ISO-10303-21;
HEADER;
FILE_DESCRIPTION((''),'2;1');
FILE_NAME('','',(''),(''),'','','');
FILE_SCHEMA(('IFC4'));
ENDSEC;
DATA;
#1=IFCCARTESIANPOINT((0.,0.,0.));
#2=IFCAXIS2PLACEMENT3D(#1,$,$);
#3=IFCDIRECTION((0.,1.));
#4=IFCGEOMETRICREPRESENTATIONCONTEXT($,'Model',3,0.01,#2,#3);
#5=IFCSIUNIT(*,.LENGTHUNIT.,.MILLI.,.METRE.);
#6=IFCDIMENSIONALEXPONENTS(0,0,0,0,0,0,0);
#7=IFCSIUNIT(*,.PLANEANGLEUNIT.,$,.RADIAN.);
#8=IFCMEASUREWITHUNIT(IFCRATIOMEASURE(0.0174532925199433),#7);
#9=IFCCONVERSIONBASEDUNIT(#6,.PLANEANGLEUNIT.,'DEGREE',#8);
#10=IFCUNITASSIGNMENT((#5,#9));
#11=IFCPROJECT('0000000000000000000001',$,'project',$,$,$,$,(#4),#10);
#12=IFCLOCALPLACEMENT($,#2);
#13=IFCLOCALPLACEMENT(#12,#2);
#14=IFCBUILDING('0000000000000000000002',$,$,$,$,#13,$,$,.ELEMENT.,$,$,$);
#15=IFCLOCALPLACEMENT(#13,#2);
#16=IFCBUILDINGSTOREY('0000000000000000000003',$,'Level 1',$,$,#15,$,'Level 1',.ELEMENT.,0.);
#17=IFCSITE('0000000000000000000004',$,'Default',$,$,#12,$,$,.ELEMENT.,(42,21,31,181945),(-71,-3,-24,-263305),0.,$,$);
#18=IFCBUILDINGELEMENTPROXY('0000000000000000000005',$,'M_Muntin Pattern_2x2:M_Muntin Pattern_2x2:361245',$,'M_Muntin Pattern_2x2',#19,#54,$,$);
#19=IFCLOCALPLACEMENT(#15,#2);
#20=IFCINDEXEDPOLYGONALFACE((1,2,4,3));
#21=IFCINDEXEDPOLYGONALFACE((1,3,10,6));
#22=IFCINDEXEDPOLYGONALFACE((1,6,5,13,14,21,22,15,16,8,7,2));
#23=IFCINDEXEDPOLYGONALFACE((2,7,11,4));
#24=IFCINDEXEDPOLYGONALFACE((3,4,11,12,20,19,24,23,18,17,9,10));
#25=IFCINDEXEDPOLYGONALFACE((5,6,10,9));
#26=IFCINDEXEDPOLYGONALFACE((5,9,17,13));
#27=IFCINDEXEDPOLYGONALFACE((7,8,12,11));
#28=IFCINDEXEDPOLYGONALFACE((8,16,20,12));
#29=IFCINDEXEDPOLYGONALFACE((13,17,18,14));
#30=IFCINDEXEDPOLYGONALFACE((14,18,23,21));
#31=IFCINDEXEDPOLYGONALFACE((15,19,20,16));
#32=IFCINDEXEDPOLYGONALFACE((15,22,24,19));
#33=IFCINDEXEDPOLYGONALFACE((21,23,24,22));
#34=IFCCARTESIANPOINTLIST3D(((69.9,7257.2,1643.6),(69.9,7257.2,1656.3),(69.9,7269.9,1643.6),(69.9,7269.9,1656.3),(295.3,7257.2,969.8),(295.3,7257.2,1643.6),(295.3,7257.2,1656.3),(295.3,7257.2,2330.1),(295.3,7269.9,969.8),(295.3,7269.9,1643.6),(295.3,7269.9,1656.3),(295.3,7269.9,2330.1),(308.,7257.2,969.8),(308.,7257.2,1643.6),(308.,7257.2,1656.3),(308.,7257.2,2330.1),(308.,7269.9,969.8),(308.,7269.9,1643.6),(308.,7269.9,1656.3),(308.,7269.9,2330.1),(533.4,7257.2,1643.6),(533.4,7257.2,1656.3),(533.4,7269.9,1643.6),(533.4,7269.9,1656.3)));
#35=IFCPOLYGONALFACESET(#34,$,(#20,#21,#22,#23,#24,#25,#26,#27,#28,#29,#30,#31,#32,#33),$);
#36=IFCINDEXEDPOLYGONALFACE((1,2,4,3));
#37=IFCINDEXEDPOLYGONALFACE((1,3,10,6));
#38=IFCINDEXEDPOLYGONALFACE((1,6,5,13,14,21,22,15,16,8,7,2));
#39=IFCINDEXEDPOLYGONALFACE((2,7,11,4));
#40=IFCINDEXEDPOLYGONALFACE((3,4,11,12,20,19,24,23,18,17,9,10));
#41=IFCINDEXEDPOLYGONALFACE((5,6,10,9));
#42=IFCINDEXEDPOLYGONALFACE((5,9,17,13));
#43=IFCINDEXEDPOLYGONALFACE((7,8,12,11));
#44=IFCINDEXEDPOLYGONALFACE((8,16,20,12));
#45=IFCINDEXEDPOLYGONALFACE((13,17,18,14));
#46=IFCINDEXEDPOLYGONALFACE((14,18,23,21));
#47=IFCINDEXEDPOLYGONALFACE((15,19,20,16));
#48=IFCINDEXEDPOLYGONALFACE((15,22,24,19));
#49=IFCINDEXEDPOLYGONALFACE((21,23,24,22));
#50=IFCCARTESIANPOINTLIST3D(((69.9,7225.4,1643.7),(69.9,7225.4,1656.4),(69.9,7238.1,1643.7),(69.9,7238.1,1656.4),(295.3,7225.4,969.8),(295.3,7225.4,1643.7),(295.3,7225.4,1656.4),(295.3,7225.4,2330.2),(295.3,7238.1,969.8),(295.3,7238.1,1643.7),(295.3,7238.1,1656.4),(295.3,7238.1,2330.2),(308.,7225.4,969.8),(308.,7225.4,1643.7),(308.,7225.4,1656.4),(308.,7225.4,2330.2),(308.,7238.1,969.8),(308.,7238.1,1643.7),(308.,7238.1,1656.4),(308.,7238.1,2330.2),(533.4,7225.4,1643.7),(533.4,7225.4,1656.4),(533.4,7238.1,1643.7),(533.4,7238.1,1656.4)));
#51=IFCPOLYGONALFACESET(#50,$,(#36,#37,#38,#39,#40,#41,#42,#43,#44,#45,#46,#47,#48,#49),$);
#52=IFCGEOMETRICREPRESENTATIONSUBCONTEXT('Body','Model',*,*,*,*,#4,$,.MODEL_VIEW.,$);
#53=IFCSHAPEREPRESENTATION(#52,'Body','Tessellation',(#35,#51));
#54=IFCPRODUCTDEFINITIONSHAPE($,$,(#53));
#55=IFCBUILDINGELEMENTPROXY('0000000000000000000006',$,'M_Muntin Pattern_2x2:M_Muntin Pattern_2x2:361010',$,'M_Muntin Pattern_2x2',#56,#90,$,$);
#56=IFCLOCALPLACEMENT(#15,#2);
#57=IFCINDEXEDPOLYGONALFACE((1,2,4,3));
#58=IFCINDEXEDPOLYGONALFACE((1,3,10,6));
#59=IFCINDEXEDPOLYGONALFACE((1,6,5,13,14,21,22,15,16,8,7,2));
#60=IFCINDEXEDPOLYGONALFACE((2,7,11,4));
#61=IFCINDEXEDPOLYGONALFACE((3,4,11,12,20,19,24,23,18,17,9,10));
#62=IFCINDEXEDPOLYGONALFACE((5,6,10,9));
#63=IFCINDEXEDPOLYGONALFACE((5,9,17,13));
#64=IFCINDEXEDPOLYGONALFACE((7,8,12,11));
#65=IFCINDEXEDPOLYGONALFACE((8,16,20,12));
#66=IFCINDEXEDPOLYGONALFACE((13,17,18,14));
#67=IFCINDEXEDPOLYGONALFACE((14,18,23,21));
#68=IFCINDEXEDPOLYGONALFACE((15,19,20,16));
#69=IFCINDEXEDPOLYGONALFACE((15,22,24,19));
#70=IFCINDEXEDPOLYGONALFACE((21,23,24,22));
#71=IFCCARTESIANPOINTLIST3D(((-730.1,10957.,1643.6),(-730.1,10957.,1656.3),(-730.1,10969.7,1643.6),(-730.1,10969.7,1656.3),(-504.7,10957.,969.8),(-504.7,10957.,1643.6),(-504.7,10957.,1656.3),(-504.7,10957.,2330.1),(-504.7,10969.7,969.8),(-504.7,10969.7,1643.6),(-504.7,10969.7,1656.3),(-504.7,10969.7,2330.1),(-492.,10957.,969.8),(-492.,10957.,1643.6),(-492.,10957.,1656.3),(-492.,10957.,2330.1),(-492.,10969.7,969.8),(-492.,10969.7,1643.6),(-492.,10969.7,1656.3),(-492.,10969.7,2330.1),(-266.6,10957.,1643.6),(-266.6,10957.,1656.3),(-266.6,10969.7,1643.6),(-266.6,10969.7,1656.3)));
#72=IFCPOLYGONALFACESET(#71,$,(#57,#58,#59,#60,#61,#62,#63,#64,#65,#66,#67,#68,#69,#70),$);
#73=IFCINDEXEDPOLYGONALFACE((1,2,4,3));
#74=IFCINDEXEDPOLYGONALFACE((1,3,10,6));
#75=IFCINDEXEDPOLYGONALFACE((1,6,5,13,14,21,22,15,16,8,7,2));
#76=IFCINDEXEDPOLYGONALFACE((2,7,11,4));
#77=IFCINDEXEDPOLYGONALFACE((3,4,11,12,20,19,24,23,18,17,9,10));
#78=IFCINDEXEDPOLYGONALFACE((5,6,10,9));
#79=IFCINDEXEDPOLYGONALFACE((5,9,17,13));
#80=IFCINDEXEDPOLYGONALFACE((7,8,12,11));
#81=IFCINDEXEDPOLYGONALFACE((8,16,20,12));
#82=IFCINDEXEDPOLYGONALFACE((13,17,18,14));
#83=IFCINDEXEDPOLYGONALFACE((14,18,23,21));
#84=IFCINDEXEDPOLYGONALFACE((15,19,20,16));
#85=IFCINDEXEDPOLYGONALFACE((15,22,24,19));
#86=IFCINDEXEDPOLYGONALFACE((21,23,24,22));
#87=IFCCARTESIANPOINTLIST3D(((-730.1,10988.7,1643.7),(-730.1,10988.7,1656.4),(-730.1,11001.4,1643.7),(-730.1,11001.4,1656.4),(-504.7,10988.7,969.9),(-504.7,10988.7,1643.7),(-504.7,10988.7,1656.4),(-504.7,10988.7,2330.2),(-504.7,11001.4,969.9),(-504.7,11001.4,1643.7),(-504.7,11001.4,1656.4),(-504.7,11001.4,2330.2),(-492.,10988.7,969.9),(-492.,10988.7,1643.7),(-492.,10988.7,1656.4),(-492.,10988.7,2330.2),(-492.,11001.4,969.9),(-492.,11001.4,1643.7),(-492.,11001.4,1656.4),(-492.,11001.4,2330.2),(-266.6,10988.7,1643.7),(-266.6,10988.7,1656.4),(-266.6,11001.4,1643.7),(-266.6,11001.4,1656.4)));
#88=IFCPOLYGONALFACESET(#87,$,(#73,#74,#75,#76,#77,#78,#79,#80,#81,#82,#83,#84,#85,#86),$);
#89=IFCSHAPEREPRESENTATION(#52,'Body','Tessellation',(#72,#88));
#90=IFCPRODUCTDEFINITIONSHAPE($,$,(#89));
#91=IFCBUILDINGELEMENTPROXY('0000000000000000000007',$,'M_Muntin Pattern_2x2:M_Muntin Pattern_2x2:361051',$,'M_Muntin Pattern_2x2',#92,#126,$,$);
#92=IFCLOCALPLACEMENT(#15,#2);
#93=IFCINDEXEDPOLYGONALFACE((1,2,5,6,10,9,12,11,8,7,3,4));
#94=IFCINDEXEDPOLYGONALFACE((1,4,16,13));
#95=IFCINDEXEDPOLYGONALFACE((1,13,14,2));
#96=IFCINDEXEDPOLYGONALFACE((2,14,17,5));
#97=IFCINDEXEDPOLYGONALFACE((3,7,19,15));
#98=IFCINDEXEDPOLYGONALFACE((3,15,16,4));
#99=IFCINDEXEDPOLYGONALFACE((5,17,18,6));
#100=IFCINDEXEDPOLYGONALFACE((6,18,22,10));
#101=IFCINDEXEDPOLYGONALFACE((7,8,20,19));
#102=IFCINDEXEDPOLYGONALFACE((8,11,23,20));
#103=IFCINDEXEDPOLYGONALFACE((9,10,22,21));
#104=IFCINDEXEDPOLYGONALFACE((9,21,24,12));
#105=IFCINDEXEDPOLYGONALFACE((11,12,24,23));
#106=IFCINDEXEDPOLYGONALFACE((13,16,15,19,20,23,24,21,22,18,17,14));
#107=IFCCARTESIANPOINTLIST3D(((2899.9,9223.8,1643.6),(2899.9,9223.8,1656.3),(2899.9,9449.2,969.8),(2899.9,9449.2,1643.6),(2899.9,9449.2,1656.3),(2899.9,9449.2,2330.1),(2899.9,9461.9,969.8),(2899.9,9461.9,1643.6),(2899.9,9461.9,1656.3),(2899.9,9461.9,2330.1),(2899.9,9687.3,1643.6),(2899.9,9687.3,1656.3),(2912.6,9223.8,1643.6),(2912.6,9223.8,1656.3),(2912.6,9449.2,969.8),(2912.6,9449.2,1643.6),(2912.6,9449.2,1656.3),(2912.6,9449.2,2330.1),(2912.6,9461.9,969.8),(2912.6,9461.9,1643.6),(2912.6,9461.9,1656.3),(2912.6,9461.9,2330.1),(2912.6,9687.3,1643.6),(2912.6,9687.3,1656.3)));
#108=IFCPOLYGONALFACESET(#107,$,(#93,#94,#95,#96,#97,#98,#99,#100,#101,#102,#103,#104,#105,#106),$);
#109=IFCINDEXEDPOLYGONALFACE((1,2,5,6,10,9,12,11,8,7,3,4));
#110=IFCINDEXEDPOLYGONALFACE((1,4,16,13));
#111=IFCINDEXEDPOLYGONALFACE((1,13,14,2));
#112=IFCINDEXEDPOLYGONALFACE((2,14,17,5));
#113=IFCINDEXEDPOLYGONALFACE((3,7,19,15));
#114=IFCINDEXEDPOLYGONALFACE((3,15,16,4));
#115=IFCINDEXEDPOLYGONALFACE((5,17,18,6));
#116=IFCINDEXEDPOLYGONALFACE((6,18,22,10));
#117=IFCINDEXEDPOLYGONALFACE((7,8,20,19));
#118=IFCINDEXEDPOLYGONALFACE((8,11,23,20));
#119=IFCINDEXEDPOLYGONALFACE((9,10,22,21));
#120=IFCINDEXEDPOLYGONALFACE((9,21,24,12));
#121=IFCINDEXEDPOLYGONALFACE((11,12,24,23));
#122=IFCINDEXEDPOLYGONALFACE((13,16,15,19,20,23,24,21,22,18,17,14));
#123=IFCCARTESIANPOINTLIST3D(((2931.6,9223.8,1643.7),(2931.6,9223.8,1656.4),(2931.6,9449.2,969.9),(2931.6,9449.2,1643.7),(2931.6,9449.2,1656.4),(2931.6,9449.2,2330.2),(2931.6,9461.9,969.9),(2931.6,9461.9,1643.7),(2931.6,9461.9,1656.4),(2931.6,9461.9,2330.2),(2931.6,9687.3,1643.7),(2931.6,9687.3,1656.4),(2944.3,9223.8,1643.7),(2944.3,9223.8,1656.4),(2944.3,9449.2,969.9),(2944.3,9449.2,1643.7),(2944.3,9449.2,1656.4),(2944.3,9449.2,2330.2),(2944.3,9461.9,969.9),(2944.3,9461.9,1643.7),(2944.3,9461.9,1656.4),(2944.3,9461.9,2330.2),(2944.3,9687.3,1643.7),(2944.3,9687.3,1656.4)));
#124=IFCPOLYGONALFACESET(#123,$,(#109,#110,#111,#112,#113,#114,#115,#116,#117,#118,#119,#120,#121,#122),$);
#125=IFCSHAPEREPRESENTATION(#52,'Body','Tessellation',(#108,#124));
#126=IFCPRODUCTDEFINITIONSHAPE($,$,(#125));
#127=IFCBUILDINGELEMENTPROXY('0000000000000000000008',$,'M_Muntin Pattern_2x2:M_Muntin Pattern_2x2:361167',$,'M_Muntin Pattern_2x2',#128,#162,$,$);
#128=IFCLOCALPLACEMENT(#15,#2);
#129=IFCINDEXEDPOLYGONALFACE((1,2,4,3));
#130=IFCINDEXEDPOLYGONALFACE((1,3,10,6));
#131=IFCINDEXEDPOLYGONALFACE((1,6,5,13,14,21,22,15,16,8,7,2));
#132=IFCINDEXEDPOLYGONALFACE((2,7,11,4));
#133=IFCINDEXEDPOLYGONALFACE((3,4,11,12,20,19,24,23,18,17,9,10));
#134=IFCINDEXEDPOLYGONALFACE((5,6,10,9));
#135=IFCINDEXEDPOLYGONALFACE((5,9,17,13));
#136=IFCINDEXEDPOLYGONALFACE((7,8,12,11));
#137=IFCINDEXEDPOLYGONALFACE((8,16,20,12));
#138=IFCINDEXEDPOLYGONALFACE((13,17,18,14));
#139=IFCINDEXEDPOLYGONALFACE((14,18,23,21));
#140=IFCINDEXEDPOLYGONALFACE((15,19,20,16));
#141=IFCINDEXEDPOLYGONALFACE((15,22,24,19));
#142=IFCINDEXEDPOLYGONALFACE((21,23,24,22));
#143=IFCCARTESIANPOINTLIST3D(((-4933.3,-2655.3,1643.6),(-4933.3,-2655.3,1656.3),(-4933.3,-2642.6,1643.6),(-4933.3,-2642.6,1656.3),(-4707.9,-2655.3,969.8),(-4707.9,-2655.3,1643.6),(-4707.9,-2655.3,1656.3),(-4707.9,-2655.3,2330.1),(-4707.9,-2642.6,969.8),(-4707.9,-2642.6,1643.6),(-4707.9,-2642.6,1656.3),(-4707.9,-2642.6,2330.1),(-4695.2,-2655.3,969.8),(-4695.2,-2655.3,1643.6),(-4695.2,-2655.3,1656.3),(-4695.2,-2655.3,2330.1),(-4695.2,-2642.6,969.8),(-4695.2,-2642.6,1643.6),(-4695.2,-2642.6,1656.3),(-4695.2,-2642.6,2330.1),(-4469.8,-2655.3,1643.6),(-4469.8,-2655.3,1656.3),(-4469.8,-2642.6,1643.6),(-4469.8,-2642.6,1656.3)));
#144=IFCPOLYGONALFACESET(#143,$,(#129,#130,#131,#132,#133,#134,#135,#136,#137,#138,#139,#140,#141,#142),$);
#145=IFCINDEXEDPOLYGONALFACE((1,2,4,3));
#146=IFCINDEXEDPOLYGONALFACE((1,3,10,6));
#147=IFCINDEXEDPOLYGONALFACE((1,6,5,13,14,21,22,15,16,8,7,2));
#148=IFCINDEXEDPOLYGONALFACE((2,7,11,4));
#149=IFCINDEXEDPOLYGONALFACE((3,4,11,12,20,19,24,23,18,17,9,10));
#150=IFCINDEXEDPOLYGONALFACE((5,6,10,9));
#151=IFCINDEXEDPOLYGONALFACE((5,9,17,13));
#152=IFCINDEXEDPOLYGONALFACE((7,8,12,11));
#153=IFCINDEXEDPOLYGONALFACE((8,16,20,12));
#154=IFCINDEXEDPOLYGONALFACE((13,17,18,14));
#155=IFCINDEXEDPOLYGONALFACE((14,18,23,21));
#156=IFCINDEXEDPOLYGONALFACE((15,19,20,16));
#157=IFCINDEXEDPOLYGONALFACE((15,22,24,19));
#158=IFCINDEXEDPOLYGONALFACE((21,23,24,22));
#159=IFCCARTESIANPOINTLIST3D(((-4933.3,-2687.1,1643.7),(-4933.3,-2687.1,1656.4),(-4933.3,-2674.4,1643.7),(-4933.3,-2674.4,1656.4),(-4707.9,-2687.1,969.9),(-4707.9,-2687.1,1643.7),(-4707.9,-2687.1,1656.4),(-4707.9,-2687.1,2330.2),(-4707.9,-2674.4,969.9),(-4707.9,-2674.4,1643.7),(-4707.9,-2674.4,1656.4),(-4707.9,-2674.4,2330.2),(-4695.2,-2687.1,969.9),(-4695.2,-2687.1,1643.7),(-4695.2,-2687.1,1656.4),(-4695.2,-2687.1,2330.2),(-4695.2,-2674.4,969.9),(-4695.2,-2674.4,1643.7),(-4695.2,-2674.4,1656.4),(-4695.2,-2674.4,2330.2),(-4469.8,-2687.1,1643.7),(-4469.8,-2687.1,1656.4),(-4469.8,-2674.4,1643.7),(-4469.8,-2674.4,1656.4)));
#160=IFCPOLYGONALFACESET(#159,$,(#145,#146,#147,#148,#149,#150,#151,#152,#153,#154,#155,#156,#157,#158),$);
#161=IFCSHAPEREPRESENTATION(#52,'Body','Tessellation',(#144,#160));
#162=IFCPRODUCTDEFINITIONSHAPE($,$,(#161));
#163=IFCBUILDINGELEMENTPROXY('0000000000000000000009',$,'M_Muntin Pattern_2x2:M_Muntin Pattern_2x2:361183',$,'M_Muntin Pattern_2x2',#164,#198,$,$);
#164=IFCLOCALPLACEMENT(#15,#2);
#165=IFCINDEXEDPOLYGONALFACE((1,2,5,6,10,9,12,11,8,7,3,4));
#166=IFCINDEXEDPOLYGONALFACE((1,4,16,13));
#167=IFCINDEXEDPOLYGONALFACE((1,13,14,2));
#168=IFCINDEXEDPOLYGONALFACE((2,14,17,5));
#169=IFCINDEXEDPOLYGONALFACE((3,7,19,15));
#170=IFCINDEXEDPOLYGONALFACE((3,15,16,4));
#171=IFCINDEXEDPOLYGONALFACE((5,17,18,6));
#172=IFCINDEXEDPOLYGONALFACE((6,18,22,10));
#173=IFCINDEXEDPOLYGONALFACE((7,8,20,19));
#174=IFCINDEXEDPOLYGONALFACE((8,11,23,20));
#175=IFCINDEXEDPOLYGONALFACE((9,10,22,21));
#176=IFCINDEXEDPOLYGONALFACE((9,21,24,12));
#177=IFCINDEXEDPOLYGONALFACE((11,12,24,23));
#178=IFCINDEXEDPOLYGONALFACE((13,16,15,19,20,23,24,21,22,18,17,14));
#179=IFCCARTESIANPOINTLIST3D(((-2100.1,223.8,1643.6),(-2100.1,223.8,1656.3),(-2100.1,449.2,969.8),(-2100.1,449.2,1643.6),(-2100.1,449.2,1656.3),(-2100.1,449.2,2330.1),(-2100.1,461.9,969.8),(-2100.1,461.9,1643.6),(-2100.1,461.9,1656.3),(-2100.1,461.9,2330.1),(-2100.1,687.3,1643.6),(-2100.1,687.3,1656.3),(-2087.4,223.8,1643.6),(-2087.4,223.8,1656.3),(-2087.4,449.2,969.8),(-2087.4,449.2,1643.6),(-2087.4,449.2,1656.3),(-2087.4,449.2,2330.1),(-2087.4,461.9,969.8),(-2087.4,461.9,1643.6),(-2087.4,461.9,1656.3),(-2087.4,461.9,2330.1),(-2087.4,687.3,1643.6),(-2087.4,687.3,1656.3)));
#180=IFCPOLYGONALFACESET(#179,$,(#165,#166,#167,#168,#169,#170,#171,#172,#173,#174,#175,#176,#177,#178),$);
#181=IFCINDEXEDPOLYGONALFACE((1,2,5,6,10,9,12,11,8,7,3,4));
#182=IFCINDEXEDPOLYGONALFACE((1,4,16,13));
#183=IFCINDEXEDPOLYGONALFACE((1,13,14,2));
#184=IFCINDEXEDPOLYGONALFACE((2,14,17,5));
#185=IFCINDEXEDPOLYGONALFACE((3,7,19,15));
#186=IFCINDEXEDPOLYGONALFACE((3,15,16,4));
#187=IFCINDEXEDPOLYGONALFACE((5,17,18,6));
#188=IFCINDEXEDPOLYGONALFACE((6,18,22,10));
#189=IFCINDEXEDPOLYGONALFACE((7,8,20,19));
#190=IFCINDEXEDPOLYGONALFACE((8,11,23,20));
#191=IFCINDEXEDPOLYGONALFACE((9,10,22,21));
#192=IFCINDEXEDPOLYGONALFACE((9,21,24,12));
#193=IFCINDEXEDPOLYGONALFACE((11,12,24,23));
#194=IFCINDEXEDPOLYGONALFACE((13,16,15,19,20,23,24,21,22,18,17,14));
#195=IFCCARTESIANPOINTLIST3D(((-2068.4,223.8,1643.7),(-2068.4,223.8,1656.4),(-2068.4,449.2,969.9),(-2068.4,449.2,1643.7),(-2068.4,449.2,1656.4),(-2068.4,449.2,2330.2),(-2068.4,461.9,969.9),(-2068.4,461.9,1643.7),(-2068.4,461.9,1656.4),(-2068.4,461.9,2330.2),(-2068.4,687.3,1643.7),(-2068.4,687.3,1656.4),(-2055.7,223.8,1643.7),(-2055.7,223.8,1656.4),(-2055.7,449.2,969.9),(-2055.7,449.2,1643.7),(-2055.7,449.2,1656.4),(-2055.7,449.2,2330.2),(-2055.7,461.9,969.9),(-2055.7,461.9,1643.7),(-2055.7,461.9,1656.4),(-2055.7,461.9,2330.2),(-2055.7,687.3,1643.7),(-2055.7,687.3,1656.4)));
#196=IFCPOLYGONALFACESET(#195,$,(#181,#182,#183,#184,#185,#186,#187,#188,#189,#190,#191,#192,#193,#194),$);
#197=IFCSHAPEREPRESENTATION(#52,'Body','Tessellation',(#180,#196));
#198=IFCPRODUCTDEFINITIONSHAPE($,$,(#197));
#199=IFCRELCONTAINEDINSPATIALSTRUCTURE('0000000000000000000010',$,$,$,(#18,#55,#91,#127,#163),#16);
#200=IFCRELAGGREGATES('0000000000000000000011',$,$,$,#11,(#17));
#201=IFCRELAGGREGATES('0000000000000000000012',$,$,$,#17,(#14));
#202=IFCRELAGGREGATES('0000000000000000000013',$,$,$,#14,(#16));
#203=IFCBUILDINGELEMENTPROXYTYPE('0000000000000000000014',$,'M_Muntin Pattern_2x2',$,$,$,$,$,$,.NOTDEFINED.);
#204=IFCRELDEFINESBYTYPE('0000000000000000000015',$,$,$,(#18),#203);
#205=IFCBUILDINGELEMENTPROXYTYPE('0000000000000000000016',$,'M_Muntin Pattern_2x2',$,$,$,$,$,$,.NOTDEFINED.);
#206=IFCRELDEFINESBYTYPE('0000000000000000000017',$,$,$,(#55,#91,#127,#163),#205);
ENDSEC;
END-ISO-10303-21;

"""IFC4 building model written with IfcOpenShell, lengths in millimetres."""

from ifc_helpers import new_model, entity, si_unit, converted_unit, direction, frame, origin, place, context, subcontext, project, spatial, polyline, outline, extrude, source, transform, mapped, type_object, type_shapes, element, save


model = new_model("IFC4")

# Units and contexts
model_context = context("Model", 3, precision=0.01, world=origin(), true_north=direction((0.0, 1.0)))
body_context = subcontext(model_context, "Body", "Model", "MODEL_VIEW")
ifc_project = project(units=[si_unit("LENGTHUNIT", "METRE", prefix="MILLI"), converted_unit("PLANEANGLEUNIT", "DEGREE", entity("IfcRatioMeasure", 0.0174532925199433), si_unit("PLANEANGLEUNIT", "RADIAN"), dimensions=[0, 0, 0, 0, 0, 0, 0])], contexts=[model_context])

# Site, building, storey
site_placement = place(None, origin())
site = spatial("IfcSite", under=ifc_project, at=site_placement, Name="Default", CompositionType="ELEMENT", RefLatitude=(42, 21, 31, 181945), RefLongitude=(-71, -3, -24, -263305), RefElevation=0.0)
building_placement = place(site_placement, origin())
building = spatial("IfcBuilding", under=site, at=building_placement, CompositionType="ELEMENT")
storey_placement = place(building_placement, origin())
storey = spatial("IfcBuildingStorey", under=building, at=storey_placement, Name="Level 1", LongName="Level 1", CompositionType="ELEMENT", Elevation=0.0)

# Building element proxies
building_element_proxy_type_1 = type_object("IfcBuildingElementProxyType", Name="M_Muntin Pattern_2x2", PredefinedType="NOTDEFINED")
shared_shape_1 = source(origin(), body_context, "Body", "SweptSolid", [
    extrude(outline(polyline([(6.4, -6.4), (680.1, -6.4), (680.1, 6.3), (6.4, 6.3), (6.4, 231.7), (-6.3, 231.7), (-6.3, 6.3), (-680.2, 6.3), (-680.2, -6.4), (-6.3, -6.4), (-6.3, -231.7), (6.4, -231.7), (6.4, -6.4)])), frame((0.0, 9.5, 680.1), z_axis=(0.0, 1.0, 0.0), x_axis=(0.0, 0.0, 1.0)), (0.0, 0.0, 1.0), 12.7),
    extrude(outline(polyline([(6.4, -6.4), (680.2, -6.4), (680.2, 6.3), (6.4, 6.3), (6.4, 231.7), (-6.3, 231.7), (-6.3, 6.3), (-680.2, 6.3), (-680.2, -6.4), (-6.3, -6.4), (-6.3, -231.7), (6.4, -231.7), (6.4, -6.4)])), frame((0.0, -22.2, 680.2), z_axis=(0.0, 1.0, 0.0), x_axis=(0.0, 0.0, 1.0)), (0.0, 0.0, 1.0), 12.7),
])
type_shapes(building_element_proxy_type_1, [shared_shape_1])
for number, where, name in (
    (1, (301.6, 7247.6, 969.8), "M_Muntin Pattern_2x2:M_Muntin Pattern_2x2:361245"),
):
    element("IfcBuildingElementProxy", number, at=place(storey_placement, frame(where)), inside=storey, type_object=building_element_proxy_type_1, Name=name, ObjectType="M_Muntin Pattern_2x2", context=body_context, shape_type="MappedRepresentation", body=[
        mapped(shared_shape_1, transform((0.0, 0.0, 0.0), scale=1.0)),
    ])
building_element_proxy_type_2 = type_object("IfcBuildingElementProxyType", Name="M_Muntin Pattern_2x2", PredefinedType="NOTDEFINED")
shared_shape_2 = source(origin(), body_context, "Body", "SweptSolid", [
    extrude(outline(polyline([(6.4, -6.4), (680.1, -6.4), (680.1, 6.3), (6.4, 6.3), (6.4, 231.7), (-6.3, 231.7), (-6.3, 6.3), (-680.2, 6.3), (-680.2, -6.4), (-6.3, -6.4), (-6.3, -231.7), (6.4, -231.7), (6.4, -6.4)])), frame((0.0, -22.2, 680.1), z_axis=(0.0, 1.0, 0.0), x_axis=(0.0, 0.0, 1.0)), (0.0, 0.0, 1.0), 12.7),
    extrude(outline(polyline([(6.4, -6.4), (680.1, -6.4), (680.1, 6.3), (6.4, 6.3), (6.4, 231.7), (-6.3, 231.7), (-6.3, 6.3), (-680.2, 6.3), (-680.2, -6.4), (-6.3, -6.4), (-6.3, -231.7), (6.4, -231.7), (6.4, -6.4)])), frame((0.0, 9.5, 680.2), z_axis=(0.0, 1.0, 0.0), x_axis=(0.0, 0.0, 1.0)), (0.0, 0.0, 1.0), 12.7),
])
type_shapes(building_element_proxy_type_2, [shared_shape_2])
proxy_1_placement = place(storey_placement, frame((-498.4, 10979.2, 969.9)))
element("IfcBuildingElementProxy", 2, at=proxy_1_placement, inside=storey, type_object=building_element_proxy_type_2, Name="M_Muntin Pattern_2x2:M_Muntin Pattern_2x2:361010", ObjectType="M_Muntin Pattern_2x2", context=body_context, shape_type="MappedRepresentation", body=[
    mapped(shared_shape_2, transform((0.0, 0.0, 0.0), scale=1.0)),
])
for number, where, z_axis, x_axis, name in (
    (3, (2922.1, 9455.6, 969.9), (0.0, 0.0, 1.0), (0.0, -1.0, 0.0), "M_Muntin Pattern_2x2:M_Muntin Pattern_2x2:361051"),
    (4, (-4701.5, -2664.9, 969.9), (0.0, 0.0, 1.0), (-1.0, 0.0, 0.0), "M_Muntin Pattern_2x2:M_Muntin Pattern_2x2:361167"),
    (5, (-2077.9, 455.6, 969.9), (0.0, 0.0, 1.0), (0.0, -1.0, 0.0), "M_Muntin Pattern_2x2:M_Muntin Pattern_2x2:361183"),
):
    element("IfcBuildingElementProxy", number, at=place(storey_placement, frame(where, z_axis=z_axis, x_axis=x_axis)), inside=storey, type_object=building_element_proxy_type_2, Name=name, ObjectType="M_Muntin Pattern_2x2", context=body_context, shape_type="MappedRepresentation", body=[
        mapped(shared_shape_2, transform((0.0, 0.0, 0.0), scale=1.0)),
    ])

save(model, "model.ifc")
